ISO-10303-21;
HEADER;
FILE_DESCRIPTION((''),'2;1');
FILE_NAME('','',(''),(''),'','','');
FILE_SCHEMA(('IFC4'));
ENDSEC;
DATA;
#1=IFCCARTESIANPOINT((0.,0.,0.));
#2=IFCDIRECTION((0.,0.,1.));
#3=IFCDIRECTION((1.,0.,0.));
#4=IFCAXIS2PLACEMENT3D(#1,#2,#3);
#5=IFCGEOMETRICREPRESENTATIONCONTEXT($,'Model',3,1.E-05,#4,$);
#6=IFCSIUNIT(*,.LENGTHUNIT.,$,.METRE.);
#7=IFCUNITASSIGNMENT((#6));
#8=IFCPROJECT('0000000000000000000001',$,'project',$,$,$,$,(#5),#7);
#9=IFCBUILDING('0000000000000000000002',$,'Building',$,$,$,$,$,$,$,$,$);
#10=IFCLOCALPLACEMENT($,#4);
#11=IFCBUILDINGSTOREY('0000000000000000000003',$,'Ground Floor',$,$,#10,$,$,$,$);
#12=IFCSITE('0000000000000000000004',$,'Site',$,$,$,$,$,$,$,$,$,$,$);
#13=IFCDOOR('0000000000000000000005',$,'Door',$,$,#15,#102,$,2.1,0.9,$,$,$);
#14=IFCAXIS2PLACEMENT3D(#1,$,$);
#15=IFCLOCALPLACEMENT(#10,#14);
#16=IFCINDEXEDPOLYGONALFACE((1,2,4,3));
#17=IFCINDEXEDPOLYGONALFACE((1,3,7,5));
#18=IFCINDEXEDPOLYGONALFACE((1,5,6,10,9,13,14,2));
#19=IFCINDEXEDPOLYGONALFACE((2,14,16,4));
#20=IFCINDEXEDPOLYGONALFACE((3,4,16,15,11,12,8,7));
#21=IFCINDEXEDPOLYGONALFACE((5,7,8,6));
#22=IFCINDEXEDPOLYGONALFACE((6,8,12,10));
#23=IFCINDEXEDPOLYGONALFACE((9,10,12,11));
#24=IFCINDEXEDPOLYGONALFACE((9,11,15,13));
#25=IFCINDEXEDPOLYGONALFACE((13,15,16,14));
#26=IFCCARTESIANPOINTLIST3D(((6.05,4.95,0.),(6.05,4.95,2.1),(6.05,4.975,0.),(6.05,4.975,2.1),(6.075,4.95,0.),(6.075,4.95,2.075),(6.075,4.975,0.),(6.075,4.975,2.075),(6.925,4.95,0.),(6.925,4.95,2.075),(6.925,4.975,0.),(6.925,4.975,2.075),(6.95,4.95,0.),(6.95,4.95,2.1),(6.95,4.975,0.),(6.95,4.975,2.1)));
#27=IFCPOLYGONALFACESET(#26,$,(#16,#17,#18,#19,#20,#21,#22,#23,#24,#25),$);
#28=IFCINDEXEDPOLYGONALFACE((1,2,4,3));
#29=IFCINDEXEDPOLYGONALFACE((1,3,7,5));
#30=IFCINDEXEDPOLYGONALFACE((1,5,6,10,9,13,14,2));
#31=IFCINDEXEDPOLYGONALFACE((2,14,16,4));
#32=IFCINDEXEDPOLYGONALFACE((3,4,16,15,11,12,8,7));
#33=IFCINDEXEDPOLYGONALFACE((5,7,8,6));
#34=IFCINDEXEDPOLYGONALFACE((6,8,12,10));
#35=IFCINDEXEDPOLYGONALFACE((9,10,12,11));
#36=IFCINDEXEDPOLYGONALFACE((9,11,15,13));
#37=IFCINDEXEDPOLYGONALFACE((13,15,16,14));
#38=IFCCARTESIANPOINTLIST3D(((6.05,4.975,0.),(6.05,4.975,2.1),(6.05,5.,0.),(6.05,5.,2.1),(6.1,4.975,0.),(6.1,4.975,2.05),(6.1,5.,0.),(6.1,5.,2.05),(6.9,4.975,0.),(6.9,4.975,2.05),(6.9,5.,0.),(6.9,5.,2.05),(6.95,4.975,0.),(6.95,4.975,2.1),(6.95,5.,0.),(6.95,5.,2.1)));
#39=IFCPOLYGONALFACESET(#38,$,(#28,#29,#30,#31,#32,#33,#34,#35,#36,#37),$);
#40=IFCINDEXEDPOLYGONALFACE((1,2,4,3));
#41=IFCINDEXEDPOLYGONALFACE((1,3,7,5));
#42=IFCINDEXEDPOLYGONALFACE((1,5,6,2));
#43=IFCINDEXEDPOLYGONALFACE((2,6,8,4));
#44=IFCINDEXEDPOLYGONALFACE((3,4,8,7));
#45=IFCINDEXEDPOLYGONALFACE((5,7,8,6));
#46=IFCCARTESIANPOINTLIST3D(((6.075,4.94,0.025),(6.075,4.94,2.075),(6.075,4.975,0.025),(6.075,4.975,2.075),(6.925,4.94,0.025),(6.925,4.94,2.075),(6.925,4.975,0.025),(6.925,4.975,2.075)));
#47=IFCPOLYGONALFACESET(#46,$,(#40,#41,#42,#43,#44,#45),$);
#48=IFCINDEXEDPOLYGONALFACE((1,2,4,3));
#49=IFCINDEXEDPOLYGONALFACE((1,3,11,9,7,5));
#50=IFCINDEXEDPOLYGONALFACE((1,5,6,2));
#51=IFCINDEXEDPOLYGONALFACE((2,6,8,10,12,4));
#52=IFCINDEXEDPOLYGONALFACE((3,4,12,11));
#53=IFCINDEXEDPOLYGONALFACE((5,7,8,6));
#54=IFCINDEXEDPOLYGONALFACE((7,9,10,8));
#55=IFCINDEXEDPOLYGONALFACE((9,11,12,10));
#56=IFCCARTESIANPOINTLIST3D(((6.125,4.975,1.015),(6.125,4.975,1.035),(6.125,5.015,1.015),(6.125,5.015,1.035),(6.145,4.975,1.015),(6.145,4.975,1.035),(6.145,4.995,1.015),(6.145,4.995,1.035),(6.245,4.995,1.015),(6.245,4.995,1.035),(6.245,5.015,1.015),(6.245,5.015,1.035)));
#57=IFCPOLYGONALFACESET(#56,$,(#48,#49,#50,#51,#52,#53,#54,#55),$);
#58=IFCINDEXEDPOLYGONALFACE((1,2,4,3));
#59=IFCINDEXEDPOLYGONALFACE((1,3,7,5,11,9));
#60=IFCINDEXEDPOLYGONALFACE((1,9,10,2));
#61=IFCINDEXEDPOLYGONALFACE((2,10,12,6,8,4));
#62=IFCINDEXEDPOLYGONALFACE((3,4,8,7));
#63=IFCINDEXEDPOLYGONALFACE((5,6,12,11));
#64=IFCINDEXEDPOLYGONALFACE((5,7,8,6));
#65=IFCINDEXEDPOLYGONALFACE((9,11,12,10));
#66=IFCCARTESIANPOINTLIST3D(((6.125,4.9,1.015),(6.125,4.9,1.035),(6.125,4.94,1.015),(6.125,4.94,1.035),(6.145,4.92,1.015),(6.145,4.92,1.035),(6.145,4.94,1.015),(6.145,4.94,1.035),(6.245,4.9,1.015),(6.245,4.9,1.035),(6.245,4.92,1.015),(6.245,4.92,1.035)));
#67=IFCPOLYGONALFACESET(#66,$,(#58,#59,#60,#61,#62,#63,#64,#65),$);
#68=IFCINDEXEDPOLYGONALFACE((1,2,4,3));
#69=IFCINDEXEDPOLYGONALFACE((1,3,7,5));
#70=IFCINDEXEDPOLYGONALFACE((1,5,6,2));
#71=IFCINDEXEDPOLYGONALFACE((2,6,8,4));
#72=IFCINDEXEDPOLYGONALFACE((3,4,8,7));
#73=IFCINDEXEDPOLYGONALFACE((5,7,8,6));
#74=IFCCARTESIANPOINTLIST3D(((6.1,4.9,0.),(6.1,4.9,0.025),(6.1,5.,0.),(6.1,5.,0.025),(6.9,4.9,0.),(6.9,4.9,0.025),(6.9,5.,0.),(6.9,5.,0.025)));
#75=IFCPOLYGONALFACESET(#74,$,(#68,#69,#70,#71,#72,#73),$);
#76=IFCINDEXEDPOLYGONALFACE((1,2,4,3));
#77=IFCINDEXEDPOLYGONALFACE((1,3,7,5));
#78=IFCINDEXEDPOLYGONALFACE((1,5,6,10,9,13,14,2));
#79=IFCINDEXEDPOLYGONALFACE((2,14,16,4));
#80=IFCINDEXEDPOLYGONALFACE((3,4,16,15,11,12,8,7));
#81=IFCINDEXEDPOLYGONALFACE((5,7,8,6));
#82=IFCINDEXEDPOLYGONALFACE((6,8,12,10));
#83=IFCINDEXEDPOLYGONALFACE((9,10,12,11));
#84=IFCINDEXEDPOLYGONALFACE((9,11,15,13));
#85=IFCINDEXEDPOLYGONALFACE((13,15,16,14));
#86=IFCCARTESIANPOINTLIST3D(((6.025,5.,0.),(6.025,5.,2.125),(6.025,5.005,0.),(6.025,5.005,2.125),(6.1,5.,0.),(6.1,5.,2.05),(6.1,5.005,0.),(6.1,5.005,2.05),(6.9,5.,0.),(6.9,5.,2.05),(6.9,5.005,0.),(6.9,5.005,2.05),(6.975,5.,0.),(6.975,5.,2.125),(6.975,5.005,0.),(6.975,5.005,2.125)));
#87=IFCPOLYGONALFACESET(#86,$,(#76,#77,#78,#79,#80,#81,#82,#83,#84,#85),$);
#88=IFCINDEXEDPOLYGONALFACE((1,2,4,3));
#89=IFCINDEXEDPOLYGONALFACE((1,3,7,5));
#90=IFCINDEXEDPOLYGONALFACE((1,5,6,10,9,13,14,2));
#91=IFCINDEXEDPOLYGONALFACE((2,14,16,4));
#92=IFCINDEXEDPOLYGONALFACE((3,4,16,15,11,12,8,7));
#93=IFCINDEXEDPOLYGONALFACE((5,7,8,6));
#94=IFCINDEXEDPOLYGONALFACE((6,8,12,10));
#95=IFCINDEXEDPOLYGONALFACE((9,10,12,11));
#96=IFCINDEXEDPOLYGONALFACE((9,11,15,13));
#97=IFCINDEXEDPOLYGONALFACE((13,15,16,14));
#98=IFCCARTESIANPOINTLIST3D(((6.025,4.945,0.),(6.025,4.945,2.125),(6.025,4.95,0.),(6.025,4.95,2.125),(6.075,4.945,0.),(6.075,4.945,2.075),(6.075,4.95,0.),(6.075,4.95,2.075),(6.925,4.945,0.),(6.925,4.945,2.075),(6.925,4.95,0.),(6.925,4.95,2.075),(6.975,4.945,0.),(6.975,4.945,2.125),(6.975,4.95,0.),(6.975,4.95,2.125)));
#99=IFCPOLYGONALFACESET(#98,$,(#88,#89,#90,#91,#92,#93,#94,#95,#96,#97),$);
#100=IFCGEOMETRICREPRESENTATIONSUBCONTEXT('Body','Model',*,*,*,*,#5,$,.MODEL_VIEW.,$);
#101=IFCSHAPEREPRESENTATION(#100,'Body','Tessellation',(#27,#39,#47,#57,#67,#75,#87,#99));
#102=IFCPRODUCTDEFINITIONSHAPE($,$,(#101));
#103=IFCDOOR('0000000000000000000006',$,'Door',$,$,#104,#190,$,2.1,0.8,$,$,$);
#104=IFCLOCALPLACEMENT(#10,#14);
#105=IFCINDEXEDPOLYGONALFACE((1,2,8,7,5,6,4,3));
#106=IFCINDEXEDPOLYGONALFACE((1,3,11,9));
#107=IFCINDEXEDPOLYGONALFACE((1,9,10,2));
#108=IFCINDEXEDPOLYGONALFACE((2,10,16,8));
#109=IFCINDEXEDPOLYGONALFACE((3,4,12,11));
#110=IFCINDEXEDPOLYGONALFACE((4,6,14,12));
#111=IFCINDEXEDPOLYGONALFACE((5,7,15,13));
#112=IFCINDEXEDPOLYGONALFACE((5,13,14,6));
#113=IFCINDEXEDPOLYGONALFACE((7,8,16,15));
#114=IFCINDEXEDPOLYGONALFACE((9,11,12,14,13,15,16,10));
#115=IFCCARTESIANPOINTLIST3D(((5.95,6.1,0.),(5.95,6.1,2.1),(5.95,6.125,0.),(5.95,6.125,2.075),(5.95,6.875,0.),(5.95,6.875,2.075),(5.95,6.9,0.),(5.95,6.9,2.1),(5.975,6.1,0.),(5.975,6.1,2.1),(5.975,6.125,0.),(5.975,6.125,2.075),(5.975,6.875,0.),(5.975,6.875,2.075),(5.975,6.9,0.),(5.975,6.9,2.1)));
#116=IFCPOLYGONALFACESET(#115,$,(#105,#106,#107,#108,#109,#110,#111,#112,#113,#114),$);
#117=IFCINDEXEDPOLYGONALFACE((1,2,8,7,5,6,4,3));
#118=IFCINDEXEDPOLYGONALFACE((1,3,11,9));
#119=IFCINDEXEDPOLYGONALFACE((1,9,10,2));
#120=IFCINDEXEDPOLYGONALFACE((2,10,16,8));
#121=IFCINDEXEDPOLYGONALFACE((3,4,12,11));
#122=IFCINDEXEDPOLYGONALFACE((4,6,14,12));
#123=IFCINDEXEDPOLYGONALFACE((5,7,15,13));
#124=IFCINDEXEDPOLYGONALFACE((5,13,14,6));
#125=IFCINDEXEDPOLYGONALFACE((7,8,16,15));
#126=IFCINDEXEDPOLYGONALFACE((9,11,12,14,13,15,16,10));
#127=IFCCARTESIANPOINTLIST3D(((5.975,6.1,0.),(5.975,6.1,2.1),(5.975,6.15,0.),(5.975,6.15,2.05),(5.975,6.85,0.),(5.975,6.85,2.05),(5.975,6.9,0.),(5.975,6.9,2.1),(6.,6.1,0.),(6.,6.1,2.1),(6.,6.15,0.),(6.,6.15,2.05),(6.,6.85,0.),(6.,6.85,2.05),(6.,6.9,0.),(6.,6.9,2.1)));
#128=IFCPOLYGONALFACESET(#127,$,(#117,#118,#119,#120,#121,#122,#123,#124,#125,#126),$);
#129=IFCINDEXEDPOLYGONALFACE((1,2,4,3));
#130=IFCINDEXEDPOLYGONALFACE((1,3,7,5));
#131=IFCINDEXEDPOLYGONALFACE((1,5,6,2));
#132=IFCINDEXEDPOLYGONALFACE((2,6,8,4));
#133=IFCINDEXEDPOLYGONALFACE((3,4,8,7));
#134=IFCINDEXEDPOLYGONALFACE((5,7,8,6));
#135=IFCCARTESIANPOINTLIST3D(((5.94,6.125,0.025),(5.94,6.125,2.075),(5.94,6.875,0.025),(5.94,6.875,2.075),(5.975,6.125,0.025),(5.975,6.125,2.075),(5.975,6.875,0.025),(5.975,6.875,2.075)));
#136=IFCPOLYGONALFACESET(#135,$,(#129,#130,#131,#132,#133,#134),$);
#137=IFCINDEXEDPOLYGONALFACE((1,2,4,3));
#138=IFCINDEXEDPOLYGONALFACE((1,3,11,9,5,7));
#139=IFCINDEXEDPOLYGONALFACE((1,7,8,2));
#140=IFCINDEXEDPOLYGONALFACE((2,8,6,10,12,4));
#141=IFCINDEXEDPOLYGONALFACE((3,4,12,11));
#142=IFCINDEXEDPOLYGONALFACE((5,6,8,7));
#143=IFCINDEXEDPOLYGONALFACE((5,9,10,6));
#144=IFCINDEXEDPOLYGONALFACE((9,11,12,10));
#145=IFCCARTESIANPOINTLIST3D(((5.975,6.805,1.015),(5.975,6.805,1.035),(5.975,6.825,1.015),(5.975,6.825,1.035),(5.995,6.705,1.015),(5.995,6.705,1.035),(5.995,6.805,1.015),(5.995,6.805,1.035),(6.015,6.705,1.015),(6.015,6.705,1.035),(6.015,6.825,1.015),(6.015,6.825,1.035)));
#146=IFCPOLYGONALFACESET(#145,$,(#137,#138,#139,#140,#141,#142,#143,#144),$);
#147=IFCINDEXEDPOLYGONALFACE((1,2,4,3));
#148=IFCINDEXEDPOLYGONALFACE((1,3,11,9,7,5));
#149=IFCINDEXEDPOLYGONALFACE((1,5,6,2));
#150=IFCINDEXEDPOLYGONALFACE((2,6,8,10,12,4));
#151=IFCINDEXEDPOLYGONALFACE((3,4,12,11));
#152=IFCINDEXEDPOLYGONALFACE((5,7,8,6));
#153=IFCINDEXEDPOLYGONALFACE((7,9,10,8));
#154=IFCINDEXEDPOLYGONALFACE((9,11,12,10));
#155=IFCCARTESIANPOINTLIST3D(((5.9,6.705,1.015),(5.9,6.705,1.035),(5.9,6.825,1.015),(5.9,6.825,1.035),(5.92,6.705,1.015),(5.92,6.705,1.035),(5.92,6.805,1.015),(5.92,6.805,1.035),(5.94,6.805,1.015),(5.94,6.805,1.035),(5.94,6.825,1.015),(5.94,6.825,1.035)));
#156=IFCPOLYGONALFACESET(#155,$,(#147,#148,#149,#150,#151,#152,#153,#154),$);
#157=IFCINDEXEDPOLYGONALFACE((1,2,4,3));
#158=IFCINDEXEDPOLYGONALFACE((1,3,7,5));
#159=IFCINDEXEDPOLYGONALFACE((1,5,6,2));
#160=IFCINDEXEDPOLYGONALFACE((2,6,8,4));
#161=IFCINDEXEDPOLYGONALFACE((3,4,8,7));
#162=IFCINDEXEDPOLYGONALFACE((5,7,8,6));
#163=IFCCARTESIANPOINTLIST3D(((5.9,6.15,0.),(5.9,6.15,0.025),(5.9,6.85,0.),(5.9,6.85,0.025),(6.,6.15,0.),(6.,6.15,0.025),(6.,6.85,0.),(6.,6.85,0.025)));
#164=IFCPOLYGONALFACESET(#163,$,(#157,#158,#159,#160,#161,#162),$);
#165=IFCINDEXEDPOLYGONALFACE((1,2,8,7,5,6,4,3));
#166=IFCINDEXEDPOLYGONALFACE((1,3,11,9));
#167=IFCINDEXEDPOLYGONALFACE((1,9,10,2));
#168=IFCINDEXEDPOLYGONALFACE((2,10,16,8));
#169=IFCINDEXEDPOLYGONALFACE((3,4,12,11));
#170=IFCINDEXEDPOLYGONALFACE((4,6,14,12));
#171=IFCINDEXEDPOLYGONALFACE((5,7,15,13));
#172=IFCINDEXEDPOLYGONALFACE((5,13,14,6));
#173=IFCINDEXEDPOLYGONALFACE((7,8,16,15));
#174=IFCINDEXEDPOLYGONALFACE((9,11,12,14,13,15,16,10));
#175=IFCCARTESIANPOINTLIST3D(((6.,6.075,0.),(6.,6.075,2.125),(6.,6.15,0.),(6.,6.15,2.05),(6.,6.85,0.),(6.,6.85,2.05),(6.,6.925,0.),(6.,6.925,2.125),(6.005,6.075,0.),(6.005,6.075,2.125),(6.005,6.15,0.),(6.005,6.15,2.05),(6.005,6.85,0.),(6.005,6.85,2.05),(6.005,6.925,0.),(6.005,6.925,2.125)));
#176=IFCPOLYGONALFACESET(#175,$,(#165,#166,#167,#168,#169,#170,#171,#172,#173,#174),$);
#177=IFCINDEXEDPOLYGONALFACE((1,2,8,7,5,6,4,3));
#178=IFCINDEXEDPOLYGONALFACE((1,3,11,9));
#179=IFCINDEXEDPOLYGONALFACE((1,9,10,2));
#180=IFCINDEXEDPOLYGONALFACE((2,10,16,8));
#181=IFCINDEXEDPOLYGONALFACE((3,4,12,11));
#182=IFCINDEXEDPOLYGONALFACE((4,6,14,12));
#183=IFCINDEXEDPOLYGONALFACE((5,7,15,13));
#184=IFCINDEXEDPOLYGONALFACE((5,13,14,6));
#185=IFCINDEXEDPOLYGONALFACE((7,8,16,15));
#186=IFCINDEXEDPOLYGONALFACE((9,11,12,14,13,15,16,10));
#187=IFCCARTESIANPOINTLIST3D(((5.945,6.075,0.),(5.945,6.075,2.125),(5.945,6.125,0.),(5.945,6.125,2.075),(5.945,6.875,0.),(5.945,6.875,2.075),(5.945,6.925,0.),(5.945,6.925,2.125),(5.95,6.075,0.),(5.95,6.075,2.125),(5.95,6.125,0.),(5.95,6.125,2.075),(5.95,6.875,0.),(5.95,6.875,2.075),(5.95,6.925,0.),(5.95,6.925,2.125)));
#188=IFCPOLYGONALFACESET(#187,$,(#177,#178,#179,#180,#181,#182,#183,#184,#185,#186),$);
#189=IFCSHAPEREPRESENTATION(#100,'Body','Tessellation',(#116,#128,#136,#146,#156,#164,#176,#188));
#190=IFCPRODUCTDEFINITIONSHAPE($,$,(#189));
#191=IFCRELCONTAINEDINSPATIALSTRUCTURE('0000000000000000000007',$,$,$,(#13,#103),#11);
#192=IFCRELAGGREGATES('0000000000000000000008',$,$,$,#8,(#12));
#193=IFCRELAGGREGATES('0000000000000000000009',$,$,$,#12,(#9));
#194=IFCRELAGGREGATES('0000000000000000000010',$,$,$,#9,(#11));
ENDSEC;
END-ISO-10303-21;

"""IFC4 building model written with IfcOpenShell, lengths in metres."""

from ifc_helpers import new_model, si_unit, frame, origin_with_axes, place, context, subcontext, project, spatial, line, indexed_curve, outline, extrude, element, save


model = new_model("IFC4")

# Units and contexts
model_context = context("Model", 3, precision=1e-05, world=origin_with_axes())
body_context = subcontext(model_context, "Body", "Model", "MODEL_VIEW")
ifc_project = project(units=[si_unit("LENGTHUNIT", "METRE")], contexts=[model_context])

# Site, building, storey
site = spatial("IfcSite", under=ifc_project, Name="Site")
building = spatial("IfcBuilding", under=site, Name="Building")
storey_placement = place(None, origin_with_axes())
storey = spatial("IfcBuildingStorey", under=building, at=storey_placement, Name="Ground Floor")

# Doors
door_1_placement = place(storey_placement, frame((6.95, 5.0, 0.0), z_axis=(0.0, 0.0, 1.0), x_axis=(-1.0, 0.0, 0.0)))
element("IfcDoor", 1, at=door_1_placement, inside=storey, Name="Door", OverallHeight=2.1, OverallWidth=0.9, context=body_context, shape_type="SweptSolid", body=[
    extrude(outline(indexed_curve([(0.0, 0.0), (0.0, 2.1), (0.9, 2.1), (0.9, 0.0), (0.875, 0.0), (0.875, 2.075), (0.025, 2.075), (0.025, 0.0)], segments=[line(1, 2, 3, 4, 5, 6, 7, 8, 1)])), frame((0.0, 0.025, 0.0), z_axis=(0.0, -1.0, 0.0), x_axis=(1.0, 0.0, 0.0)), (0.0, 0.0, -1.0), 0.025),
    extrude(outline(indexed_curve([(0.0, 0.0), (0.0, 2.1), (0.9, 2.1), (0.9, 0.0), (0.85, 0.0), (0.85, 2.05), (0.05, 2.05), (0.05, 0.0)], segments=[line(1, 2, 3, 4, 5, 6, 7, 8, 1)])), frame((0.0, 0.0, 0.0), z_axis=(0.0, -1.0, 0.0), x_axis=(1.0, 0.0, 0.0)), (0.0, 0.0, -1.0), 0.025),
    extrude(outline(indexed_curve([(0.0, 0.0), (0.85, 0.0), (0.85, 0.035), (0.0, 0.035)], segments=[line(1, 2, 3, 4, 1)])), frame((0.025, 0.025, 0.025), z_axis=(0.0, 0.0, 1.0), x_axis=(1.0, 0.0, 0.0)), (0.0, 0.0, 1.0), 2.05),
    extrude(outline(indexed_curve([(0.0, 0.0), (0.0, -0.04), (-0.12, -0.04), (-0.12, -0.02), (-0.02, -0.02), (-0.02, 0.0)], segments=[line(1, 2, 3, 4, 5, 6, 1)])), frame((0.825, 0.025, 1.015), z_axis=(0.0, 0.0, 1.0), x_axis=(1.0, 0.0, 0.0)), (0.0, 0.0, 1.0), 0.02),
    extrude(outline(indexed_curve([(0.0, 0.0), (0.0, 0.04), (-0.12, 0.04), (-0.12, 0.02), (-0.02, 0.02), (-0.02, 0.0)], segments=[line(1, 2, 3, 4, 5, 6, 1)])), frame((0.825, 0.06, 1.015), z_axis=(0.0, 0.0, 1.0), x_axis=(1.0, 0.0, 0.0)), (0.0, 0.0, 1.0), 0.02),
    extrude(outline(indexed_curve([(0.0, 0.0), (0.8, 0.0), (0.8, 0.1), (0.0, 0.1)], segments=[line(1, 2, 3, 4, 1)])), frame((0.05, 0.0, 0.0), z_axis=(0.0, 0.0, 1.0), x_axis=(1.0, 0.0, 0.0)), (0.0, 0.0, 1.0), 0.025),
    extrude(outline(indexed_curve([(0.0, 0.0), (0.0, 2.125), (0.95, 2.125), (0.95, 0.0), (0.875, 0.0), (0.875, 2.05), (0.075, 2.05), (0.075, 0.0)], segments=[line(1, 2, 3, 4, 5, 6, 7, 8, 1)])), frame((-0.025, -0.005, 0.0), z_axis=(0.0, -1.0, 0.0), x_axis=(1.0, 0.0, 0.0)), (0.0, 0.0, -1.0), 0.005),
    extrude(outline(indexed_curve([(0.0, 0.0), (0.0, 2.125), (0.95, 2.125), (0.95, 0.0), (0.9, 0.0), (0.9, 2.075), (0.05, 2.075), (0.05, 0.0)], segments=[line(1, 2, 3, 4, 5, 6, 7, 8, 1)])), frame((-0.025, 0.05, 0.0), z_axis=(0.0, -1.0, 0.0), x_axis=(1.0, 0.0, 0.0)), (0.0, 0.0, -1.0), 0.005),
])
door_2_placement = place(storey_placement, frame((6.0, 6.1, 0.0), z_axis=(0.0, 0.0, 1.0), x_axis=(0.0, 1.0, 0.0)))
element("IfcDoor", 2, at=door_2_placement, inside=storey, Name="Door", OverallHeight=2.1, OverallWidth=0.8, context=body_context, shape_type="SweptSolid", body=[
    extrude(outline(indexed_curve([(0.0, 0.0), (0.0, 2.1), (0.8, 2.1), (0.8, 0.0), (0.775, 0.0), (0.775, 2.075), (0.025, 2.075), (0.025, 0.0)], segments=[line(1, 2, 3, 4, 5, 6, 7, 8, 1)])), frame((0.0, 0.025, 0.0), z_axis=(0.0, -1.0, 0.0), x_axis=(1.0, 0.0, 0.0)), (0.0, 0.0, -1.0), 0.025),
    extrude(outline(indexed_curve([(0.0, 0.0), (0.0, 2.1), (0.8, 2.1), (0.8, 0.0), (0.75, 0.0), (0.75, 2.05), (0.05, 2.05), (0.05, 0.0)], segments=[line(1, 2, 3, 4, 5, 6, 7, 8, 1)])), frame((0.0, 0.0, 0.0), z_axis=(0.0, -1.0, 0.0), x_axis=(1.0, 0.0, 0.0)), (0.0, 0.0, -1.0), 0.025),
    extrude(outline(indexed_curve([(0.0, 0.0), (0.75, 0.0), (0.75, 0.035), (0.0, 0.035)], segments=[line(1, 2, 3, 4, 1)])), frame((0.025, 0.025, 0.025), z_axis=(0.0, 0.0, 1.0), x_axis=(1.0, 0.0, 0.0)), (0.0, 0.0, 1.0), 2.05),
    extrude(outline(indexed_curve([(0.0, 0.0), (0.0, -0.04), (-0.12, -0.04), (-0.12, -0.02), (-0.02, -0.02), (-0.02, 0.0)], segments=[line(1, 2, 3, 4, 5, 6, 1)])), frame((0.725, 0.025, 1.015), z_axis=(0.0, 0.0, 1.0), x_axis=(1.0, 0.0, 0.0)), (0.0, 0.0, 1.0), 0.02),
    extrude(outline(indexed_curve([(0.0, 0.0), (0.0, 0.04), (-0.12, 0.04), (-0.12, 0.02), (-0.02, 0.02), (-0.02, 0.0)], segments=[line(1, 2, 3, 4, 5, 6, 1)])), frame((0.725, 0.06, 1.015), z_axis=(0.0, 0.0, 1.0), x_axis=(1.0, 0.0, 0.0)), (0.0, 0.0, 1.0), 0.02),
    extrude(outline(indexed_curve([(0.0, 0.0), (0.7, 0.0), (0.7, 0.1), (0.0, 0.1)], segments=[line(1, 2, 3, 4, 1)])), frame((0.05, 0.0, 0.0), z_axis=(0.0, 0.0, 1.0), x_axis=(1.0, 0.0, 0.0)), (0.0, 0.0, 1.0), 0.025),
    extrude(outline(indexed_curve([(0.0, 0.0), (0.0, 2.125), (0.85, 2.125), (0.85, 0.0), (0.775, 0.0), (0.775, 2.05), (0.075, 2.05), (0.075, 0.0)], segments=[line(1, 2, 3, 4, 5, 6, 7, 8, 1)])), frame((-0.025, -0.005, 0.0), z_axis=(0.0, -1.0, 0.0), x_axis=(1.0, 0.0, 0.0)), (0.0, 0.0, -1.0), 0.005),
    extrude(outline(indexed_curve([(0.0, 0.0), (0.0, 2.125), (0.85, 2.125), (0.85, 0.0), (0.8, 0.0), (0.8, 2.075), (0.05, 2.075), (0.05, 0.0)], segments=[line(1, 2, 3, 4, 5, 6, 7, 8, 1)])), frame((-0.025, 0.05, 0.0), z_axis=(0.0, -1.0, 0.0), x_axis=(1.0, 0.0, 0.0)), (0.0, 0.0, -1.0), 0.005),
])

save(model, "model.ifc")
